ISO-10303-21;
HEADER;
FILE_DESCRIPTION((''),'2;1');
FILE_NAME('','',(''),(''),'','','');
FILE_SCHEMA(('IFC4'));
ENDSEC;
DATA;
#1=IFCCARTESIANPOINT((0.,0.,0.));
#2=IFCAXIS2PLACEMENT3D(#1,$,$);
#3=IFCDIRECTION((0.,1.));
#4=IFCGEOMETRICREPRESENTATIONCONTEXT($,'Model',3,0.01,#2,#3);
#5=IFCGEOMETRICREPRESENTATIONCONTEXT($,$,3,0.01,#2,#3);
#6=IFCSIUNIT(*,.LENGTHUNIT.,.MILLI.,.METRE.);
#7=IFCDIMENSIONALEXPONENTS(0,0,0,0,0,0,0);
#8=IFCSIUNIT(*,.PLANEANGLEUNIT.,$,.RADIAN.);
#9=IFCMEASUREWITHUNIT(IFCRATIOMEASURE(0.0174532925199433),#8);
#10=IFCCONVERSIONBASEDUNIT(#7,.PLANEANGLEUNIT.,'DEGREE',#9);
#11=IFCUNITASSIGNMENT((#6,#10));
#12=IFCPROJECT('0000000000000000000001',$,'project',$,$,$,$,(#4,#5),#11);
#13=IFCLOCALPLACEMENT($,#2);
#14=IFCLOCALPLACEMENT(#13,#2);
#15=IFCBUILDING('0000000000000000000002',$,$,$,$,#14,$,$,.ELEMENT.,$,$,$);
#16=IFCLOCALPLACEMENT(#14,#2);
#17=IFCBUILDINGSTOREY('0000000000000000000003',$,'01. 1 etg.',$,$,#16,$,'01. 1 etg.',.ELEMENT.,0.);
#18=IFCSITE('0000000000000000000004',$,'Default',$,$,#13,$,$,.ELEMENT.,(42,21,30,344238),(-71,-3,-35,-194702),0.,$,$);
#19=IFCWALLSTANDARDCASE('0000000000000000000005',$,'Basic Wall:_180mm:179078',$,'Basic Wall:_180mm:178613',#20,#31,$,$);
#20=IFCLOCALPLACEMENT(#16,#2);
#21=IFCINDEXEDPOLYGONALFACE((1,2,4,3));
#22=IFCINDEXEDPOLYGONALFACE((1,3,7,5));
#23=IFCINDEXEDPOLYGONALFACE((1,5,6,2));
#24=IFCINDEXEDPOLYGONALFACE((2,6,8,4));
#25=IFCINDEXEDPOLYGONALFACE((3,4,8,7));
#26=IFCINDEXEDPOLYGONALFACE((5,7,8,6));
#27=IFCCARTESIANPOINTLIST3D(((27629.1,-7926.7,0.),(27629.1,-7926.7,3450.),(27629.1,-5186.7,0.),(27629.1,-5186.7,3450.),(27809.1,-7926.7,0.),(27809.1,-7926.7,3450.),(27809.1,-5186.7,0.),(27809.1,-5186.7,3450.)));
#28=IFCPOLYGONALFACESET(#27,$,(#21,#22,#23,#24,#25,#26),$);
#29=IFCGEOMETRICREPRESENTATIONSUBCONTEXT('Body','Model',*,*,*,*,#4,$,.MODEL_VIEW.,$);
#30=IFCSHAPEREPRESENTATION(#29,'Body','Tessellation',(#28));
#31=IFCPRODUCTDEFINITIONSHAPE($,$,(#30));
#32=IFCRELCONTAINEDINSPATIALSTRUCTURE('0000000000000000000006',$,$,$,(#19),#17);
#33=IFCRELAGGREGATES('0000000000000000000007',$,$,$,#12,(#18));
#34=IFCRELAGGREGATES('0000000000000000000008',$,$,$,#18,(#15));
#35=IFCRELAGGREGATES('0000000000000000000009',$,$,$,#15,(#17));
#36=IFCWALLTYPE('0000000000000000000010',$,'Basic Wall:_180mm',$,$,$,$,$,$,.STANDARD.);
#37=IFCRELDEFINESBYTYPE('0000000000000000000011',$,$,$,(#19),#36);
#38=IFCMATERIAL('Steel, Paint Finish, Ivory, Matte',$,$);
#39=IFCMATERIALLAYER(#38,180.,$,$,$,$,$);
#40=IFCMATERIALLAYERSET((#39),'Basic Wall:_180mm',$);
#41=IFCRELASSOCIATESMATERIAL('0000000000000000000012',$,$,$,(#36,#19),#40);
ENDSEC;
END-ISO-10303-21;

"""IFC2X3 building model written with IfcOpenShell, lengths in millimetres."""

from ifc_helpers import new_model, entity, si_unit, converted_unit, direction, frame, frame_2d, origin, place, context, subcontext, project, spatial, polyline, rectangle, extrude, clip, bounded_halfspace, material, layer, layer_set, layer_usage, type_object, element, save


model = new_model("IFC2X3")

# Units and contexts
model_context = context("Model", 3, precision=0.01, world=origin(), true_north=direction((0.0, 1.0)))
context_of_model = context(None, 3, precision=0.01, world=origin(), true_north=direction((0.0, 1.0)))
body_context = subcontext(model_context, "Body", "Model", "MODEL_VIEW")
ifc_project = project(units=[si_unit("LENGTHUNIT", "METRE", prefix="MILLI"), converted_unit("PLANEANGLEUNIT", "DEGREE", entity("IfcRatioMeasure", 0.0174532925199433), si_unit("PLANEANGLEUNIT", "RADIAN"), dimensions=[0, 0, 0, 0, 0, 0, 0])], contexts=[model_context, context_of_model])

# Site, building, storey
site_placement = place(None, origin())
site = spatial("IfcSite", under=ifc_project, at=site_placement, Name="Default", CompositionType="ELEMENT", RefLatitude=(42, 21, 30, 344238), RefLongitude=(-71, -3, -35, -194702), RefElevation=0.0)
building_placement = place(site_placement, origin())
building = spatial("IfcBuilding", under=site, at=building_placement, CompositionType="ELEMENT")
storey_placement = place(building_placement, origin())
storey = spatial("IfcBuildingStorey", under=building, at=storey_placement, Name="01. 1 etg.", LongName="01. 1 etg.", CompositionType="ELEMENT", Elevation=0.0)

# Shared definitions
ifc_material_1 = material(Name="Steel, Paint Finish, Ivory, Matte")

# Shared definitions
ifc_layer_1 = layer(ifc_material_1, 180.0)
ifc_layer_set_1 = layer_set([ifc_layer_1], Name="Basic Wall:_180mm")
wall_type_1 = type_object("IfcWallType", Name="Basic Wall:_180mm", PredefinedType="STANDARD", material=ifc_layer_set_1)

# Wall
ifc_layer_usage_1 = layer_usage(ifc_layer_set_1, "AXIS2", "POSITIVE", -90.0)
wall_1_placement = place(storey_placement, frame((27719.1, -5186.7, 0.0), z_axis=(0.0, 0.0, 1.0), x_axis=(0.0, -1.0, 0.0)))
element("IfcWallStandardCase", 1, at=wall_1_placement, inside=storey, type_object=wall_type_1, material=ifc_layer_usage_1, Name="Basic Wall:_180mm:179078", ObjectType="Basic Wall:_180mm:178613", context=body_context, shape_type="Clipping", body=[
    clip(extrude(rectangle(XDim=2740.0, YDim=180.0, at=frame_2d((1370.0, 0.0), x_axis=(-1.0, 0.0))), origin(), (0.0, 0.0, 1.0), 3450.0), bounded_halfspace(frame((0.0, -90.0, 3450.0), z_axis=(0.0, 0.0, -1.0), x_axis=(1.0, 0.0, 0.0)), True, frame((0.0, -90.0, 3450.0)), polyline([(0.0, 0.0), (2740.0, 0.0), (2740.0, 180.0), (0.0, 180.0), (0.0, 0.0)]))),
])

save(model, "model.ifc")
